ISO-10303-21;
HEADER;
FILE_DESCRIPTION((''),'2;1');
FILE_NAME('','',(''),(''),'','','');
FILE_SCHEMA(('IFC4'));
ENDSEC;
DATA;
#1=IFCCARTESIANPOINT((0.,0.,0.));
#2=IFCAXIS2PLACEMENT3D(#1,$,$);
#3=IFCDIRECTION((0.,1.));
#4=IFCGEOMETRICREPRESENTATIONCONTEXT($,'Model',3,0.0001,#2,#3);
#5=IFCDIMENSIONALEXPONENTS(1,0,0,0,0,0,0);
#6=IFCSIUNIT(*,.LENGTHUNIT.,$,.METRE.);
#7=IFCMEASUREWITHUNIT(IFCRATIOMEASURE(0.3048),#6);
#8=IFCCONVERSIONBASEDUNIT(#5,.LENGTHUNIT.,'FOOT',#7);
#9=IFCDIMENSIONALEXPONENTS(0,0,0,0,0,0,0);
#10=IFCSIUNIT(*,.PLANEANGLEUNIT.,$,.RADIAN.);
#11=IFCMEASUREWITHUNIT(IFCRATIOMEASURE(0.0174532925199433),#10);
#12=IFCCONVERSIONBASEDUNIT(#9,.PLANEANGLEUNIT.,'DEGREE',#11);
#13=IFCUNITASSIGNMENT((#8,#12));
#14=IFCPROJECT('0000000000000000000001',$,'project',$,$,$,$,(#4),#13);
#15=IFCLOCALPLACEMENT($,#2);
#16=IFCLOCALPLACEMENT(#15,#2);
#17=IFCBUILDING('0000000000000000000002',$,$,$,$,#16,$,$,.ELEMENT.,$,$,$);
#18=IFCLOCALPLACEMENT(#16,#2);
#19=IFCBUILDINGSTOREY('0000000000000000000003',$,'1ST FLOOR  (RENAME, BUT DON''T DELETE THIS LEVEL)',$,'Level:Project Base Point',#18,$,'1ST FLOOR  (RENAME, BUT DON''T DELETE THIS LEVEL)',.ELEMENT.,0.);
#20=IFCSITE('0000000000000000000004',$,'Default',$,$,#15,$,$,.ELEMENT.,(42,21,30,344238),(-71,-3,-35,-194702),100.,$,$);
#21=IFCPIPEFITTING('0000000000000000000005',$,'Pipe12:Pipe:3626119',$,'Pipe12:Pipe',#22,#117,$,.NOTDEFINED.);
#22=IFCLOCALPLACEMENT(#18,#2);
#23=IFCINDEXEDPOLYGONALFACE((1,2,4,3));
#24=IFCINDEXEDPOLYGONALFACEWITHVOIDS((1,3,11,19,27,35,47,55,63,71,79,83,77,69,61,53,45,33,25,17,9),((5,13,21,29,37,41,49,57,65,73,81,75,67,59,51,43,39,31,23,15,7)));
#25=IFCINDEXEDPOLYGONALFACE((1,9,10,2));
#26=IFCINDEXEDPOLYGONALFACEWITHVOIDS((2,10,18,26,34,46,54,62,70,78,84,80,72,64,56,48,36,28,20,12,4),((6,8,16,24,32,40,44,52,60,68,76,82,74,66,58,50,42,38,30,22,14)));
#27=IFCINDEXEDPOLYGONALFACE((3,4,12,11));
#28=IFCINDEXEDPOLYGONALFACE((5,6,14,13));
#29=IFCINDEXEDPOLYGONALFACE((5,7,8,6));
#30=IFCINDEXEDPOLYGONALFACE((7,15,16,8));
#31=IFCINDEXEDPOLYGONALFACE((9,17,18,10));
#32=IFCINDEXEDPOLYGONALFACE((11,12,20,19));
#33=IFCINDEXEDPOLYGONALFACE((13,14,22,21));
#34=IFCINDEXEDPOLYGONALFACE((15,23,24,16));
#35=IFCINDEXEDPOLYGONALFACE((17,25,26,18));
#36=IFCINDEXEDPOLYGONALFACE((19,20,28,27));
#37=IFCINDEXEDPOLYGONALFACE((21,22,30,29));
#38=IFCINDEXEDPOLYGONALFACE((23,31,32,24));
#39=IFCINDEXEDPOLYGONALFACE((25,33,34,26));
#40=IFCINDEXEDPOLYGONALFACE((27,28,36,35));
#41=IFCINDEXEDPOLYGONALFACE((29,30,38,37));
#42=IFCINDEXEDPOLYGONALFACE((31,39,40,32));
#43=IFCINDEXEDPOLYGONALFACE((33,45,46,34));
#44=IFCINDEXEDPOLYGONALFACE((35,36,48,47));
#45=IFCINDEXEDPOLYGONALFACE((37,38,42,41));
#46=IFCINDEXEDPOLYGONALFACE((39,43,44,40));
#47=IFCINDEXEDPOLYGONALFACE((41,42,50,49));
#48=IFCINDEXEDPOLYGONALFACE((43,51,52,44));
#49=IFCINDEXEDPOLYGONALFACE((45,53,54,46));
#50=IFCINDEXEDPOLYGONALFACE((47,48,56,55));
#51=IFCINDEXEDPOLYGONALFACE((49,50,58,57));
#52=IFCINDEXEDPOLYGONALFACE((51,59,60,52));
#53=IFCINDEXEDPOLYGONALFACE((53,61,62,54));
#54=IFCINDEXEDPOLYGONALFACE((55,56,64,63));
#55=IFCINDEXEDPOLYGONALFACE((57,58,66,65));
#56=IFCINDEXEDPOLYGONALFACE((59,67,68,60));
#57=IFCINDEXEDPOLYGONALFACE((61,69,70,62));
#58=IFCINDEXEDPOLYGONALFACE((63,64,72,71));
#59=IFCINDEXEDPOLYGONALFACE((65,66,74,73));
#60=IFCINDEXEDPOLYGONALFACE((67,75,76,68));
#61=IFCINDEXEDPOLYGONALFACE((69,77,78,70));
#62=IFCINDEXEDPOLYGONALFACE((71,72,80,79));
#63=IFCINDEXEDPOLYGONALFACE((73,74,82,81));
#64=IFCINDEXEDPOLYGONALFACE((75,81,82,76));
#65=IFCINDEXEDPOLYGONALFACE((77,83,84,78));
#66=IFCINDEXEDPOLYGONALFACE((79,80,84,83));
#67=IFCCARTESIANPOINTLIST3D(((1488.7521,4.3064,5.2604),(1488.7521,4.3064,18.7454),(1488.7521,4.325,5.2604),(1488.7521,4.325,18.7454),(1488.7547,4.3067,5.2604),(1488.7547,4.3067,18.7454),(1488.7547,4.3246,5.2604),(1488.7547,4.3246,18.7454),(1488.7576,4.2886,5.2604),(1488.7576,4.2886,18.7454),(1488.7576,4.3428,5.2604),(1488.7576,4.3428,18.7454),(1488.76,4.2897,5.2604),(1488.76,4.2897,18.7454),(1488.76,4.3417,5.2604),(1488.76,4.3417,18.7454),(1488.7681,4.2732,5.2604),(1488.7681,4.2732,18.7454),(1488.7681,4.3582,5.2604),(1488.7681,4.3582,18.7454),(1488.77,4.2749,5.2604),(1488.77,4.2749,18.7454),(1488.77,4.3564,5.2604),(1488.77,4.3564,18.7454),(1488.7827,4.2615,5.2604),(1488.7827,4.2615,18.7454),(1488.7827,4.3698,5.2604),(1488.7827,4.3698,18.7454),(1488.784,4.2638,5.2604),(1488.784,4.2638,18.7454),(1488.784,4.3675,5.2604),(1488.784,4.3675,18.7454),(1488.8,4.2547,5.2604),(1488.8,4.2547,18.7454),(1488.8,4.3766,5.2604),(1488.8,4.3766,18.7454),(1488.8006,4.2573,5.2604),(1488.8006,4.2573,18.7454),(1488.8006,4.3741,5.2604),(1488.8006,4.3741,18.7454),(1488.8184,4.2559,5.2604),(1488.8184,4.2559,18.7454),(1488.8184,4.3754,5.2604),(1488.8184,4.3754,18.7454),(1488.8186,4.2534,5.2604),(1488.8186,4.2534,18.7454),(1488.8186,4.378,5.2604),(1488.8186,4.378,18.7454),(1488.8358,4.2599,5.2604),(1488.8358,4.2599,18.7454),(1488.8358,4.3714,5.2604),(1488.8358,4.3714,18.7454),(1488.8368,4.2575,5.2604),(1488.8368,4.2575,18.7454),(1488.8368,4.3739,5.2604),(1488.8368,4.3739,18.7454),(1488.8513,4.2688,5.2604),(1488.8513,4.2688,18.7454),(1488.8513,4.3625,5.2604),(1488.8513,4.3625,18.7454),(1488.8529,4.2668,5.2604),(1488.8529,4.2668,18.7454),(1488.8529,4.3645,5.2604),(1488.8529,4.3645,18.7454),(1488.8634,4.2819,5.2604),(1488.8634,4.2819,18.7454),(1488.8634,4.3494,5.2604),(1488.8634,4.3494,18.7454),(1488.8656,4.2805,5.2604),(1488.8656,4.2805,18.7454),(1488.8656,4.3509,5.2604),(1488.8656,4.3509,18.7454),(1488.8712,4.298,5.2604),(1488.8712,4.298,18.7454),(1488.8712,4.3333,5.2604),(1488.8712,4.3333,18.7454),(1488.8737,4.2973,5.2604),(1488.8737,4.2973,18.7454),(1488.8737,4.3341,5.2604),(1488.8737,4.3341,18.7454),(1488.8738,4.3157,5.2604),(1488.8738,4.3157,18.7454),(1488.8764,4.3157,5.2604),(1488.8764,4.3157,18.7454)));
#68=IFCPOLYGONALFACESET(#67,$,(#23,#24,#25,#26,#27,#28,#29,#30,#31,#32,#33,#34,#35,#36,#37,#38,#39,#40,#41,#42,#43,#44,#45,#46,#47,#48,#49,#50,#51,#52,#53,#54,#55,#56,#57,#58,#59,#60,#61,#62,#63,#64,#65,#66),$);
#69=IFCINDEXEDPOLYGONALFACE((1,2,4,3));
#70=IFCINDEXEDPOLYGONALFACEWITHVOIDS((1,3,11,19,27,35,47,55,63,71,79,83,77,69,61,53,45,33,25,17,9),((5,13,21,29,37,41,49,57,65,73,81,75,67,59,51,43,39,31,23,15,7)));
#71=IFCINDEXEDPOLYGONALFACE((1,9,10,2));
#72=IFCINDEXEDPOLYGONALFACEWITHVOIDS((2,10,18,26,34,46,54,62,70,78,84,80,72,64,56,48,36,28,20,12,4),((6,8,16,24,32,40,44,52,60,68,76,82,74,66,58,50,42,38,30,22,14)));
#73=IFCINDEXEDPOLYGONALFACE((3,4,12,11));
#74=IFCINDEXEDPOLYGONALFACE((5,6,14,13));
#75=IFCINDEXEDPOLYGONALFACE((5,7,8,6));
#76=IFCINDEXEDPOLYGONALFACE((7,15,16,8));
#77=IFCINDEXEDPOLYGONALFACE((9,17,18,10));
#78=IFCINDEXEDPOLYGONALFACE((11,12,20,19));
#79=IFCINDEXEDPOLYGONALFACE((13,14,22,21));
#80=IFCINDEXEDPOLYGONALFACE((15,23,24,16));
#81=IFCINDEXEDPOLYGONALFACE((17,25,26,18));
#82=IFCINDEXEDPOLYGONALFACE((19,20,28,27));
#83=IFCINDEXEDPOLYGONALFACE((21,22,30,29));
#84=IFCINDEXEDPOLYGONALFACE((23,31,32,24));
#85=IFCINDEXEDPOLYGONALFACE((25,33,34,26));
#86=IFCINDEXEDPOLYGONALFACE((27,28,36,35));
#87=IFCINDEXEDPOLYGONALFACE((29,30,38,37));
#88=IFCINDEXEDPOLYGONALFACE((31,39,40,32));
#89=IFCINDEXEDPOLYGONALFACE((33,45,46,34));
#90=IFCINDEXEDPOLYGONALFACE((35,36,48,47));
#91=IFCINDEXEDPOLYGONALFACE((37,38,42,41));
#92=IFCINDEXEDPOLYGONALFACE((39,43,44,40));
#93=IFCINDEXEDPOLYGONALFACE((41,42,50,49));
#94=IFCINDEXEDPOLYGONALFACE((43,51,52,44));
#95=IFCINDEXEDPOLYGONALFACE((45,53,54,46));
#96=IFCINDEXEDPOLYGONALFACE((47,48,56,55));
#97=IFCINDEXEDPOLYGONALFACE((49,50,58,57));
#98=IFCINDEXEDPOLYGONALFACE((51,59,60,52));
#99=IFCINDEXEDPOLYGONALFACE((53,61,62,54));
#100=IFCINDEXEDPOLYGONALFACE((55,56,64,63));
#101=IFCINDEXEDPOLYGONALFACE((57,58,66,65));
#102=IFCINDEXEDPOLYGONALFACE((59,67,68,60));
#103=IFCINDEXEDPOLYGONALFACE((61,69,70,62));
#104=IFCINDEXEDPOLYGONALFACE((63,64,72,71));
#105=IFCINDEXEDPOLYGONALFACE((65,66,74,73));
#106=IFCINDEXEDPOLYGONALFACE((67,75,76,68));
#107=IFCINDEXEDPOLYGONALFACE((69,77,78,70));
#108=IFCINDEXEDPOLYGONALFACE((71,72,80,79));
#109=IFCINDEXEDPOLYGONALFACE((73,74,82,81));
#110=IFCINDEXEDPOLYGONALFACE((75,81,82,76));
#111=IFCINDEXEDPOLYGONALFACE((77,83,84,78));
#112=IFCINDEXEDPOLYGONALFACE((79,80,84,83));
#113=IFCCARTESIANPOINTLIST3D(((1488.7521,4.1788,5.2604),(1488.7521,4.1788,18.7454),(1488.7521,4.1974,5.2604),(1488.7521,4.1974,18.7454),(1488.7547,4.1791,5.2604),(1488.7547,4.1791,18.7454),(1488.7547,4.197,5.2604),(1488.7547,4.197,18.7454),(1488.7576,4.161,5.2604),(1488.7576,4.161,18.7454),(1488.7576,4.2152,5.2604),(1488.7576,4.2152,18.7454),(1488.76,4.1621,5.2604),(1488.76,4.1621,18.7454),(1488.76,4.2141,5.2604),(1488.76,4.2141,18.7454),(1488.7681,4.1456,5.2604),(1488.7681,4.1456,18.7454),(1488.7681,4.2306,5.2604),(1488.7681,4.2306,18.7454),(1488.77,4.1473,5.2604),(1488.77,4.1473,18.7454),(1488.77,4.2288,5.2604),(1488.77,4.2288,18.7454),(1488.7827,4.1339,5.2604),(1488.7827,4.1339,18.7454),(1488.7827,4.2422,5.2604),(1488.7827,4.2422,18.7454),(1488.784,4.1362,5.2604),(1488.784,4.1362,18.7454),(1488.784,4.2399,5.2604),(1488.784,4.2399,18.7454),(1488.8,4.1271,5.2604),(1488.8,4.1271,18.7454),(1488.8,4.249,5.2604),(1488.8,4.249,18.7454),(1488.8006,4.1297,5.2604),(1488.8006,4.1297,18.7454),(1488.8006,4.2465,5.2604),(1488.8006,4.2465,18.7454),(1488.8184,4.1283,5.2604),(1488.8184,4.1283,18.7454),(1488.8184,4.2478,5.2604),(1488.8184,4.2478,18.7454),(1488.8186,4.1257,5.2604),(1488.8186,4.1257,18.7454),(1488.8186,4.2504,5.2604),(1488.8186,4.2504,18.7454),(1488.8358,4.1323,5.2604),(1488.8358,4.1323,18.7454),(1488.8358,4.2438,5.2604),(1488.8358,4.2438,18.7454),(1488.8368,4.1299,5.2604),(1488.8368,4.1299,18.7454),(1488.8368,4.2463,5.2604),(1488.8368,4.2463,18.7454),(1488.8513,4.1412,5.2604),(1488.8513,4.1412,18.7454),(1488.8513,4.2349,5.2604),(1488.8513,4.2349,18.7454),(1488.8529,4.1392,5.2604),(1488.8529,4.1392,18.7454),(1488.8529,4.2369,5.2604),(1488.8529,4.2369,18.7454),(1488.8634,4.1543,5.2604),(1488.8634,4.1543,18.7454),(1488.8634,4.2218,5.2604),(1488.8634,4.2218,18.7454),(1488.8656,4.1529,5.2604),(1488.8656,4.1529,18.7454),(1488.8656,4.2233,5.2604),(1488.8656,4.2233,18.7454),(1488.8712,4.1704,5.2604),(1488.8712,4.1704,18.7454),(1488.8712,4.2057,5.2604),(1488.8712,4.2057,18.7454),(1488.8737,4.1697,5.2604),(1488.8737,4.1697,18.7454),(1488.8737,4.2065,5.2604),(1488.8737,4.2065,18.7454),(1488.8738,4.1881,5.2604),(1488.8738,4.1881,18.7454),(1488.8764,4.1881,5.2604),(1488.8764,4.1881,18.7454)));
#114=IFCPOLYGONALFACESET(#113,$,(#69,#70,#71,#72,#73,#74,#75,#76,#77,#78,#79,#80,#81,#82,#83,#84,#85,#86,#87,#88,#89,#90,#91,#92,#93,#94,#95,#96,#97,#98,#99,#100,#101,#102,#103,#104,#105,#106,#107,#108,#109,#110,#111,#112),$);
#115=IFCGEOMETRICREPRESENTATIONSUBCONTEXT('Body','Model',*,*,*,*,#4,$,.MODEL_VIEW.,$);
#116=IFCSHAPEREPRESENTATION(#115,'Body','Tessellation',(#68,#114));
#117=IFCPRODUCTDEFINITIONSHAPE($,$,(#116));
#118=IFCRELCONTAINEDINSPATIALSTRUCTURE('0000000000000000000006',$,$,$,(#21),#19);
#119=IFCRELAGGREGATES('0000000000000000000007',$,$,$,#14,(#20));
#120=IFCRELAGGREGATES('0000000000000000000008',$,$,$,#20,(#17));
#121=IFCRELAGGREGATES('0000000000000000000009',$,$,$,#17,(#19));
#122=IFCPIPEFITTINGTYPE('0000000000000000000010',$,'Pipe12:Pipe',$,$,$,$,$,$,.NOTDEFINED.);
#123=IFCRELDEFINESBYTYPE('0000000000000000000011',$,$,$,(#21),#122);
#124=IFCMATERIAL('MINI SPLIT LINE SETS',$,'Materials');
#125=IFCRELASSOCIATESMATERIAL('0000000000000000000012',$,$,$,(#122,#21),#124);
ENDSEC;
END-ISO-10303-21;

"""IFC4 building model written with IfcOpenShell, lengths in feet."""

from ifc_helpers import new_model, entity, si_unit, converted_unit, direction, frame, origin, origin_2d_with_axis, place, context, subcontext, project, spatial, hollow_circle, extrude, source, transform, mapped, material, type_object, type_shapes, element, save


model = new_model("IFC4")

# Units and contexts
model_context = context("Model", 3, precision=0.0001, world=origin(), true_north=direction((0.0, 1.0)))
body_context = subcontext(model_context, "Body", "Model", "MODEL_VIEW")
ifc_project = project(units=[converted_unit("LENGTHUNIT", "FOOT", entity("IfcRatioMeasure", 0.3048), si_unit("LENGTHUNIT", "METRE"), dimensions=[1, 0, 0, 0, 0, 0, 0]), converted_unit("PLANEANGLEUNIT", "DEGREE", entity("IfcRatioMeasure", 0.0174532925199433), si_unit("PLANEANGLEUNIT", "RADIAN"), dimensions=[0, 0, 0, 0, 0, 0, 0])], contexts=[model_context])

# Site, building, storey
site_placement = place(None, origin())
site = spatial("IfcSite", under=ifc_project, at=site_placement, Name="Default", CompositionType="ELEMENT", RefLatitude=(42, 21, 30, 344238), RefLongitude=(-71, -3, -35, -194702), RefElevation=100.0)
building_placement = place(site_placement, origin())
building = spatial("IfcBuilding", under=site, at=building_placement, CompositionType="ELEMENT")
storey_placement = place(building_placement, origin())
storey = spatial("IfcBuildingStorey", under=building, at=storey_placement, Name="1ST FLOOR  (RENAME, BUT DON'T DELETE THIS LEVEL)", ObjectType="Level:Project Base Point", LongName="1ST FLOOR  (RENAME, BUT DON'T DELETE THIS LEVEL)", CompositionType="ELEMENT", Elevation=0.0)

# Shared definitions
ifc_material_1 = material(Name="MINI SPLIT LINE SETS", Category="Materials")

# Pipe fitting
pipe_fitting_type_1 = type_object("IfcPipeFittingType", Name="Pipe12:Pipe", PredefinedType="NOTDEFINED", material=ifc_material_1)
shared_shape_1 = source(origin(), body_context, "Body", "SweptSolid", [
    extrude(hollow_circle(Radius=0.0625, WallThickness=0.0026, at=origin_2d_with_axis()), frame((0.0677, 0.1953, 0.0)), (0.0, 0.0, 1.0), 13.485),
    extrude(hollow_circle(Radius=0.0625, WallThickness=0.0026, at=origin_2d_with_axis()), frame((0.0677, 0.0677, 0.0)), (0.0, 0.0, 1.0), 13.485),
])
type_shapes(pipe_fitting_type_1, [shared_shape_1])
pipe_fitting_1_placement = place(storey_placement, frame((1488.7462, 4.1203, 5.2604)))
element("IfcPipeFitting", 1, at=pipe_fitting_1_placement, inside=storey, type_object=pipe_fitting_type_1, material=ifc_material_1, Name="Pipe12:Pipe:3626119", ObjectType="Pipe12:Pipe", PredefinedType="NOTDEFINED", context=body_context, shape_type="MappedRepresentation", body=[
    mapped(shared_shape_1, transform((0.0, 0.0, 0.0), scale=1.0)),
])

save(model, "model.ifc")
